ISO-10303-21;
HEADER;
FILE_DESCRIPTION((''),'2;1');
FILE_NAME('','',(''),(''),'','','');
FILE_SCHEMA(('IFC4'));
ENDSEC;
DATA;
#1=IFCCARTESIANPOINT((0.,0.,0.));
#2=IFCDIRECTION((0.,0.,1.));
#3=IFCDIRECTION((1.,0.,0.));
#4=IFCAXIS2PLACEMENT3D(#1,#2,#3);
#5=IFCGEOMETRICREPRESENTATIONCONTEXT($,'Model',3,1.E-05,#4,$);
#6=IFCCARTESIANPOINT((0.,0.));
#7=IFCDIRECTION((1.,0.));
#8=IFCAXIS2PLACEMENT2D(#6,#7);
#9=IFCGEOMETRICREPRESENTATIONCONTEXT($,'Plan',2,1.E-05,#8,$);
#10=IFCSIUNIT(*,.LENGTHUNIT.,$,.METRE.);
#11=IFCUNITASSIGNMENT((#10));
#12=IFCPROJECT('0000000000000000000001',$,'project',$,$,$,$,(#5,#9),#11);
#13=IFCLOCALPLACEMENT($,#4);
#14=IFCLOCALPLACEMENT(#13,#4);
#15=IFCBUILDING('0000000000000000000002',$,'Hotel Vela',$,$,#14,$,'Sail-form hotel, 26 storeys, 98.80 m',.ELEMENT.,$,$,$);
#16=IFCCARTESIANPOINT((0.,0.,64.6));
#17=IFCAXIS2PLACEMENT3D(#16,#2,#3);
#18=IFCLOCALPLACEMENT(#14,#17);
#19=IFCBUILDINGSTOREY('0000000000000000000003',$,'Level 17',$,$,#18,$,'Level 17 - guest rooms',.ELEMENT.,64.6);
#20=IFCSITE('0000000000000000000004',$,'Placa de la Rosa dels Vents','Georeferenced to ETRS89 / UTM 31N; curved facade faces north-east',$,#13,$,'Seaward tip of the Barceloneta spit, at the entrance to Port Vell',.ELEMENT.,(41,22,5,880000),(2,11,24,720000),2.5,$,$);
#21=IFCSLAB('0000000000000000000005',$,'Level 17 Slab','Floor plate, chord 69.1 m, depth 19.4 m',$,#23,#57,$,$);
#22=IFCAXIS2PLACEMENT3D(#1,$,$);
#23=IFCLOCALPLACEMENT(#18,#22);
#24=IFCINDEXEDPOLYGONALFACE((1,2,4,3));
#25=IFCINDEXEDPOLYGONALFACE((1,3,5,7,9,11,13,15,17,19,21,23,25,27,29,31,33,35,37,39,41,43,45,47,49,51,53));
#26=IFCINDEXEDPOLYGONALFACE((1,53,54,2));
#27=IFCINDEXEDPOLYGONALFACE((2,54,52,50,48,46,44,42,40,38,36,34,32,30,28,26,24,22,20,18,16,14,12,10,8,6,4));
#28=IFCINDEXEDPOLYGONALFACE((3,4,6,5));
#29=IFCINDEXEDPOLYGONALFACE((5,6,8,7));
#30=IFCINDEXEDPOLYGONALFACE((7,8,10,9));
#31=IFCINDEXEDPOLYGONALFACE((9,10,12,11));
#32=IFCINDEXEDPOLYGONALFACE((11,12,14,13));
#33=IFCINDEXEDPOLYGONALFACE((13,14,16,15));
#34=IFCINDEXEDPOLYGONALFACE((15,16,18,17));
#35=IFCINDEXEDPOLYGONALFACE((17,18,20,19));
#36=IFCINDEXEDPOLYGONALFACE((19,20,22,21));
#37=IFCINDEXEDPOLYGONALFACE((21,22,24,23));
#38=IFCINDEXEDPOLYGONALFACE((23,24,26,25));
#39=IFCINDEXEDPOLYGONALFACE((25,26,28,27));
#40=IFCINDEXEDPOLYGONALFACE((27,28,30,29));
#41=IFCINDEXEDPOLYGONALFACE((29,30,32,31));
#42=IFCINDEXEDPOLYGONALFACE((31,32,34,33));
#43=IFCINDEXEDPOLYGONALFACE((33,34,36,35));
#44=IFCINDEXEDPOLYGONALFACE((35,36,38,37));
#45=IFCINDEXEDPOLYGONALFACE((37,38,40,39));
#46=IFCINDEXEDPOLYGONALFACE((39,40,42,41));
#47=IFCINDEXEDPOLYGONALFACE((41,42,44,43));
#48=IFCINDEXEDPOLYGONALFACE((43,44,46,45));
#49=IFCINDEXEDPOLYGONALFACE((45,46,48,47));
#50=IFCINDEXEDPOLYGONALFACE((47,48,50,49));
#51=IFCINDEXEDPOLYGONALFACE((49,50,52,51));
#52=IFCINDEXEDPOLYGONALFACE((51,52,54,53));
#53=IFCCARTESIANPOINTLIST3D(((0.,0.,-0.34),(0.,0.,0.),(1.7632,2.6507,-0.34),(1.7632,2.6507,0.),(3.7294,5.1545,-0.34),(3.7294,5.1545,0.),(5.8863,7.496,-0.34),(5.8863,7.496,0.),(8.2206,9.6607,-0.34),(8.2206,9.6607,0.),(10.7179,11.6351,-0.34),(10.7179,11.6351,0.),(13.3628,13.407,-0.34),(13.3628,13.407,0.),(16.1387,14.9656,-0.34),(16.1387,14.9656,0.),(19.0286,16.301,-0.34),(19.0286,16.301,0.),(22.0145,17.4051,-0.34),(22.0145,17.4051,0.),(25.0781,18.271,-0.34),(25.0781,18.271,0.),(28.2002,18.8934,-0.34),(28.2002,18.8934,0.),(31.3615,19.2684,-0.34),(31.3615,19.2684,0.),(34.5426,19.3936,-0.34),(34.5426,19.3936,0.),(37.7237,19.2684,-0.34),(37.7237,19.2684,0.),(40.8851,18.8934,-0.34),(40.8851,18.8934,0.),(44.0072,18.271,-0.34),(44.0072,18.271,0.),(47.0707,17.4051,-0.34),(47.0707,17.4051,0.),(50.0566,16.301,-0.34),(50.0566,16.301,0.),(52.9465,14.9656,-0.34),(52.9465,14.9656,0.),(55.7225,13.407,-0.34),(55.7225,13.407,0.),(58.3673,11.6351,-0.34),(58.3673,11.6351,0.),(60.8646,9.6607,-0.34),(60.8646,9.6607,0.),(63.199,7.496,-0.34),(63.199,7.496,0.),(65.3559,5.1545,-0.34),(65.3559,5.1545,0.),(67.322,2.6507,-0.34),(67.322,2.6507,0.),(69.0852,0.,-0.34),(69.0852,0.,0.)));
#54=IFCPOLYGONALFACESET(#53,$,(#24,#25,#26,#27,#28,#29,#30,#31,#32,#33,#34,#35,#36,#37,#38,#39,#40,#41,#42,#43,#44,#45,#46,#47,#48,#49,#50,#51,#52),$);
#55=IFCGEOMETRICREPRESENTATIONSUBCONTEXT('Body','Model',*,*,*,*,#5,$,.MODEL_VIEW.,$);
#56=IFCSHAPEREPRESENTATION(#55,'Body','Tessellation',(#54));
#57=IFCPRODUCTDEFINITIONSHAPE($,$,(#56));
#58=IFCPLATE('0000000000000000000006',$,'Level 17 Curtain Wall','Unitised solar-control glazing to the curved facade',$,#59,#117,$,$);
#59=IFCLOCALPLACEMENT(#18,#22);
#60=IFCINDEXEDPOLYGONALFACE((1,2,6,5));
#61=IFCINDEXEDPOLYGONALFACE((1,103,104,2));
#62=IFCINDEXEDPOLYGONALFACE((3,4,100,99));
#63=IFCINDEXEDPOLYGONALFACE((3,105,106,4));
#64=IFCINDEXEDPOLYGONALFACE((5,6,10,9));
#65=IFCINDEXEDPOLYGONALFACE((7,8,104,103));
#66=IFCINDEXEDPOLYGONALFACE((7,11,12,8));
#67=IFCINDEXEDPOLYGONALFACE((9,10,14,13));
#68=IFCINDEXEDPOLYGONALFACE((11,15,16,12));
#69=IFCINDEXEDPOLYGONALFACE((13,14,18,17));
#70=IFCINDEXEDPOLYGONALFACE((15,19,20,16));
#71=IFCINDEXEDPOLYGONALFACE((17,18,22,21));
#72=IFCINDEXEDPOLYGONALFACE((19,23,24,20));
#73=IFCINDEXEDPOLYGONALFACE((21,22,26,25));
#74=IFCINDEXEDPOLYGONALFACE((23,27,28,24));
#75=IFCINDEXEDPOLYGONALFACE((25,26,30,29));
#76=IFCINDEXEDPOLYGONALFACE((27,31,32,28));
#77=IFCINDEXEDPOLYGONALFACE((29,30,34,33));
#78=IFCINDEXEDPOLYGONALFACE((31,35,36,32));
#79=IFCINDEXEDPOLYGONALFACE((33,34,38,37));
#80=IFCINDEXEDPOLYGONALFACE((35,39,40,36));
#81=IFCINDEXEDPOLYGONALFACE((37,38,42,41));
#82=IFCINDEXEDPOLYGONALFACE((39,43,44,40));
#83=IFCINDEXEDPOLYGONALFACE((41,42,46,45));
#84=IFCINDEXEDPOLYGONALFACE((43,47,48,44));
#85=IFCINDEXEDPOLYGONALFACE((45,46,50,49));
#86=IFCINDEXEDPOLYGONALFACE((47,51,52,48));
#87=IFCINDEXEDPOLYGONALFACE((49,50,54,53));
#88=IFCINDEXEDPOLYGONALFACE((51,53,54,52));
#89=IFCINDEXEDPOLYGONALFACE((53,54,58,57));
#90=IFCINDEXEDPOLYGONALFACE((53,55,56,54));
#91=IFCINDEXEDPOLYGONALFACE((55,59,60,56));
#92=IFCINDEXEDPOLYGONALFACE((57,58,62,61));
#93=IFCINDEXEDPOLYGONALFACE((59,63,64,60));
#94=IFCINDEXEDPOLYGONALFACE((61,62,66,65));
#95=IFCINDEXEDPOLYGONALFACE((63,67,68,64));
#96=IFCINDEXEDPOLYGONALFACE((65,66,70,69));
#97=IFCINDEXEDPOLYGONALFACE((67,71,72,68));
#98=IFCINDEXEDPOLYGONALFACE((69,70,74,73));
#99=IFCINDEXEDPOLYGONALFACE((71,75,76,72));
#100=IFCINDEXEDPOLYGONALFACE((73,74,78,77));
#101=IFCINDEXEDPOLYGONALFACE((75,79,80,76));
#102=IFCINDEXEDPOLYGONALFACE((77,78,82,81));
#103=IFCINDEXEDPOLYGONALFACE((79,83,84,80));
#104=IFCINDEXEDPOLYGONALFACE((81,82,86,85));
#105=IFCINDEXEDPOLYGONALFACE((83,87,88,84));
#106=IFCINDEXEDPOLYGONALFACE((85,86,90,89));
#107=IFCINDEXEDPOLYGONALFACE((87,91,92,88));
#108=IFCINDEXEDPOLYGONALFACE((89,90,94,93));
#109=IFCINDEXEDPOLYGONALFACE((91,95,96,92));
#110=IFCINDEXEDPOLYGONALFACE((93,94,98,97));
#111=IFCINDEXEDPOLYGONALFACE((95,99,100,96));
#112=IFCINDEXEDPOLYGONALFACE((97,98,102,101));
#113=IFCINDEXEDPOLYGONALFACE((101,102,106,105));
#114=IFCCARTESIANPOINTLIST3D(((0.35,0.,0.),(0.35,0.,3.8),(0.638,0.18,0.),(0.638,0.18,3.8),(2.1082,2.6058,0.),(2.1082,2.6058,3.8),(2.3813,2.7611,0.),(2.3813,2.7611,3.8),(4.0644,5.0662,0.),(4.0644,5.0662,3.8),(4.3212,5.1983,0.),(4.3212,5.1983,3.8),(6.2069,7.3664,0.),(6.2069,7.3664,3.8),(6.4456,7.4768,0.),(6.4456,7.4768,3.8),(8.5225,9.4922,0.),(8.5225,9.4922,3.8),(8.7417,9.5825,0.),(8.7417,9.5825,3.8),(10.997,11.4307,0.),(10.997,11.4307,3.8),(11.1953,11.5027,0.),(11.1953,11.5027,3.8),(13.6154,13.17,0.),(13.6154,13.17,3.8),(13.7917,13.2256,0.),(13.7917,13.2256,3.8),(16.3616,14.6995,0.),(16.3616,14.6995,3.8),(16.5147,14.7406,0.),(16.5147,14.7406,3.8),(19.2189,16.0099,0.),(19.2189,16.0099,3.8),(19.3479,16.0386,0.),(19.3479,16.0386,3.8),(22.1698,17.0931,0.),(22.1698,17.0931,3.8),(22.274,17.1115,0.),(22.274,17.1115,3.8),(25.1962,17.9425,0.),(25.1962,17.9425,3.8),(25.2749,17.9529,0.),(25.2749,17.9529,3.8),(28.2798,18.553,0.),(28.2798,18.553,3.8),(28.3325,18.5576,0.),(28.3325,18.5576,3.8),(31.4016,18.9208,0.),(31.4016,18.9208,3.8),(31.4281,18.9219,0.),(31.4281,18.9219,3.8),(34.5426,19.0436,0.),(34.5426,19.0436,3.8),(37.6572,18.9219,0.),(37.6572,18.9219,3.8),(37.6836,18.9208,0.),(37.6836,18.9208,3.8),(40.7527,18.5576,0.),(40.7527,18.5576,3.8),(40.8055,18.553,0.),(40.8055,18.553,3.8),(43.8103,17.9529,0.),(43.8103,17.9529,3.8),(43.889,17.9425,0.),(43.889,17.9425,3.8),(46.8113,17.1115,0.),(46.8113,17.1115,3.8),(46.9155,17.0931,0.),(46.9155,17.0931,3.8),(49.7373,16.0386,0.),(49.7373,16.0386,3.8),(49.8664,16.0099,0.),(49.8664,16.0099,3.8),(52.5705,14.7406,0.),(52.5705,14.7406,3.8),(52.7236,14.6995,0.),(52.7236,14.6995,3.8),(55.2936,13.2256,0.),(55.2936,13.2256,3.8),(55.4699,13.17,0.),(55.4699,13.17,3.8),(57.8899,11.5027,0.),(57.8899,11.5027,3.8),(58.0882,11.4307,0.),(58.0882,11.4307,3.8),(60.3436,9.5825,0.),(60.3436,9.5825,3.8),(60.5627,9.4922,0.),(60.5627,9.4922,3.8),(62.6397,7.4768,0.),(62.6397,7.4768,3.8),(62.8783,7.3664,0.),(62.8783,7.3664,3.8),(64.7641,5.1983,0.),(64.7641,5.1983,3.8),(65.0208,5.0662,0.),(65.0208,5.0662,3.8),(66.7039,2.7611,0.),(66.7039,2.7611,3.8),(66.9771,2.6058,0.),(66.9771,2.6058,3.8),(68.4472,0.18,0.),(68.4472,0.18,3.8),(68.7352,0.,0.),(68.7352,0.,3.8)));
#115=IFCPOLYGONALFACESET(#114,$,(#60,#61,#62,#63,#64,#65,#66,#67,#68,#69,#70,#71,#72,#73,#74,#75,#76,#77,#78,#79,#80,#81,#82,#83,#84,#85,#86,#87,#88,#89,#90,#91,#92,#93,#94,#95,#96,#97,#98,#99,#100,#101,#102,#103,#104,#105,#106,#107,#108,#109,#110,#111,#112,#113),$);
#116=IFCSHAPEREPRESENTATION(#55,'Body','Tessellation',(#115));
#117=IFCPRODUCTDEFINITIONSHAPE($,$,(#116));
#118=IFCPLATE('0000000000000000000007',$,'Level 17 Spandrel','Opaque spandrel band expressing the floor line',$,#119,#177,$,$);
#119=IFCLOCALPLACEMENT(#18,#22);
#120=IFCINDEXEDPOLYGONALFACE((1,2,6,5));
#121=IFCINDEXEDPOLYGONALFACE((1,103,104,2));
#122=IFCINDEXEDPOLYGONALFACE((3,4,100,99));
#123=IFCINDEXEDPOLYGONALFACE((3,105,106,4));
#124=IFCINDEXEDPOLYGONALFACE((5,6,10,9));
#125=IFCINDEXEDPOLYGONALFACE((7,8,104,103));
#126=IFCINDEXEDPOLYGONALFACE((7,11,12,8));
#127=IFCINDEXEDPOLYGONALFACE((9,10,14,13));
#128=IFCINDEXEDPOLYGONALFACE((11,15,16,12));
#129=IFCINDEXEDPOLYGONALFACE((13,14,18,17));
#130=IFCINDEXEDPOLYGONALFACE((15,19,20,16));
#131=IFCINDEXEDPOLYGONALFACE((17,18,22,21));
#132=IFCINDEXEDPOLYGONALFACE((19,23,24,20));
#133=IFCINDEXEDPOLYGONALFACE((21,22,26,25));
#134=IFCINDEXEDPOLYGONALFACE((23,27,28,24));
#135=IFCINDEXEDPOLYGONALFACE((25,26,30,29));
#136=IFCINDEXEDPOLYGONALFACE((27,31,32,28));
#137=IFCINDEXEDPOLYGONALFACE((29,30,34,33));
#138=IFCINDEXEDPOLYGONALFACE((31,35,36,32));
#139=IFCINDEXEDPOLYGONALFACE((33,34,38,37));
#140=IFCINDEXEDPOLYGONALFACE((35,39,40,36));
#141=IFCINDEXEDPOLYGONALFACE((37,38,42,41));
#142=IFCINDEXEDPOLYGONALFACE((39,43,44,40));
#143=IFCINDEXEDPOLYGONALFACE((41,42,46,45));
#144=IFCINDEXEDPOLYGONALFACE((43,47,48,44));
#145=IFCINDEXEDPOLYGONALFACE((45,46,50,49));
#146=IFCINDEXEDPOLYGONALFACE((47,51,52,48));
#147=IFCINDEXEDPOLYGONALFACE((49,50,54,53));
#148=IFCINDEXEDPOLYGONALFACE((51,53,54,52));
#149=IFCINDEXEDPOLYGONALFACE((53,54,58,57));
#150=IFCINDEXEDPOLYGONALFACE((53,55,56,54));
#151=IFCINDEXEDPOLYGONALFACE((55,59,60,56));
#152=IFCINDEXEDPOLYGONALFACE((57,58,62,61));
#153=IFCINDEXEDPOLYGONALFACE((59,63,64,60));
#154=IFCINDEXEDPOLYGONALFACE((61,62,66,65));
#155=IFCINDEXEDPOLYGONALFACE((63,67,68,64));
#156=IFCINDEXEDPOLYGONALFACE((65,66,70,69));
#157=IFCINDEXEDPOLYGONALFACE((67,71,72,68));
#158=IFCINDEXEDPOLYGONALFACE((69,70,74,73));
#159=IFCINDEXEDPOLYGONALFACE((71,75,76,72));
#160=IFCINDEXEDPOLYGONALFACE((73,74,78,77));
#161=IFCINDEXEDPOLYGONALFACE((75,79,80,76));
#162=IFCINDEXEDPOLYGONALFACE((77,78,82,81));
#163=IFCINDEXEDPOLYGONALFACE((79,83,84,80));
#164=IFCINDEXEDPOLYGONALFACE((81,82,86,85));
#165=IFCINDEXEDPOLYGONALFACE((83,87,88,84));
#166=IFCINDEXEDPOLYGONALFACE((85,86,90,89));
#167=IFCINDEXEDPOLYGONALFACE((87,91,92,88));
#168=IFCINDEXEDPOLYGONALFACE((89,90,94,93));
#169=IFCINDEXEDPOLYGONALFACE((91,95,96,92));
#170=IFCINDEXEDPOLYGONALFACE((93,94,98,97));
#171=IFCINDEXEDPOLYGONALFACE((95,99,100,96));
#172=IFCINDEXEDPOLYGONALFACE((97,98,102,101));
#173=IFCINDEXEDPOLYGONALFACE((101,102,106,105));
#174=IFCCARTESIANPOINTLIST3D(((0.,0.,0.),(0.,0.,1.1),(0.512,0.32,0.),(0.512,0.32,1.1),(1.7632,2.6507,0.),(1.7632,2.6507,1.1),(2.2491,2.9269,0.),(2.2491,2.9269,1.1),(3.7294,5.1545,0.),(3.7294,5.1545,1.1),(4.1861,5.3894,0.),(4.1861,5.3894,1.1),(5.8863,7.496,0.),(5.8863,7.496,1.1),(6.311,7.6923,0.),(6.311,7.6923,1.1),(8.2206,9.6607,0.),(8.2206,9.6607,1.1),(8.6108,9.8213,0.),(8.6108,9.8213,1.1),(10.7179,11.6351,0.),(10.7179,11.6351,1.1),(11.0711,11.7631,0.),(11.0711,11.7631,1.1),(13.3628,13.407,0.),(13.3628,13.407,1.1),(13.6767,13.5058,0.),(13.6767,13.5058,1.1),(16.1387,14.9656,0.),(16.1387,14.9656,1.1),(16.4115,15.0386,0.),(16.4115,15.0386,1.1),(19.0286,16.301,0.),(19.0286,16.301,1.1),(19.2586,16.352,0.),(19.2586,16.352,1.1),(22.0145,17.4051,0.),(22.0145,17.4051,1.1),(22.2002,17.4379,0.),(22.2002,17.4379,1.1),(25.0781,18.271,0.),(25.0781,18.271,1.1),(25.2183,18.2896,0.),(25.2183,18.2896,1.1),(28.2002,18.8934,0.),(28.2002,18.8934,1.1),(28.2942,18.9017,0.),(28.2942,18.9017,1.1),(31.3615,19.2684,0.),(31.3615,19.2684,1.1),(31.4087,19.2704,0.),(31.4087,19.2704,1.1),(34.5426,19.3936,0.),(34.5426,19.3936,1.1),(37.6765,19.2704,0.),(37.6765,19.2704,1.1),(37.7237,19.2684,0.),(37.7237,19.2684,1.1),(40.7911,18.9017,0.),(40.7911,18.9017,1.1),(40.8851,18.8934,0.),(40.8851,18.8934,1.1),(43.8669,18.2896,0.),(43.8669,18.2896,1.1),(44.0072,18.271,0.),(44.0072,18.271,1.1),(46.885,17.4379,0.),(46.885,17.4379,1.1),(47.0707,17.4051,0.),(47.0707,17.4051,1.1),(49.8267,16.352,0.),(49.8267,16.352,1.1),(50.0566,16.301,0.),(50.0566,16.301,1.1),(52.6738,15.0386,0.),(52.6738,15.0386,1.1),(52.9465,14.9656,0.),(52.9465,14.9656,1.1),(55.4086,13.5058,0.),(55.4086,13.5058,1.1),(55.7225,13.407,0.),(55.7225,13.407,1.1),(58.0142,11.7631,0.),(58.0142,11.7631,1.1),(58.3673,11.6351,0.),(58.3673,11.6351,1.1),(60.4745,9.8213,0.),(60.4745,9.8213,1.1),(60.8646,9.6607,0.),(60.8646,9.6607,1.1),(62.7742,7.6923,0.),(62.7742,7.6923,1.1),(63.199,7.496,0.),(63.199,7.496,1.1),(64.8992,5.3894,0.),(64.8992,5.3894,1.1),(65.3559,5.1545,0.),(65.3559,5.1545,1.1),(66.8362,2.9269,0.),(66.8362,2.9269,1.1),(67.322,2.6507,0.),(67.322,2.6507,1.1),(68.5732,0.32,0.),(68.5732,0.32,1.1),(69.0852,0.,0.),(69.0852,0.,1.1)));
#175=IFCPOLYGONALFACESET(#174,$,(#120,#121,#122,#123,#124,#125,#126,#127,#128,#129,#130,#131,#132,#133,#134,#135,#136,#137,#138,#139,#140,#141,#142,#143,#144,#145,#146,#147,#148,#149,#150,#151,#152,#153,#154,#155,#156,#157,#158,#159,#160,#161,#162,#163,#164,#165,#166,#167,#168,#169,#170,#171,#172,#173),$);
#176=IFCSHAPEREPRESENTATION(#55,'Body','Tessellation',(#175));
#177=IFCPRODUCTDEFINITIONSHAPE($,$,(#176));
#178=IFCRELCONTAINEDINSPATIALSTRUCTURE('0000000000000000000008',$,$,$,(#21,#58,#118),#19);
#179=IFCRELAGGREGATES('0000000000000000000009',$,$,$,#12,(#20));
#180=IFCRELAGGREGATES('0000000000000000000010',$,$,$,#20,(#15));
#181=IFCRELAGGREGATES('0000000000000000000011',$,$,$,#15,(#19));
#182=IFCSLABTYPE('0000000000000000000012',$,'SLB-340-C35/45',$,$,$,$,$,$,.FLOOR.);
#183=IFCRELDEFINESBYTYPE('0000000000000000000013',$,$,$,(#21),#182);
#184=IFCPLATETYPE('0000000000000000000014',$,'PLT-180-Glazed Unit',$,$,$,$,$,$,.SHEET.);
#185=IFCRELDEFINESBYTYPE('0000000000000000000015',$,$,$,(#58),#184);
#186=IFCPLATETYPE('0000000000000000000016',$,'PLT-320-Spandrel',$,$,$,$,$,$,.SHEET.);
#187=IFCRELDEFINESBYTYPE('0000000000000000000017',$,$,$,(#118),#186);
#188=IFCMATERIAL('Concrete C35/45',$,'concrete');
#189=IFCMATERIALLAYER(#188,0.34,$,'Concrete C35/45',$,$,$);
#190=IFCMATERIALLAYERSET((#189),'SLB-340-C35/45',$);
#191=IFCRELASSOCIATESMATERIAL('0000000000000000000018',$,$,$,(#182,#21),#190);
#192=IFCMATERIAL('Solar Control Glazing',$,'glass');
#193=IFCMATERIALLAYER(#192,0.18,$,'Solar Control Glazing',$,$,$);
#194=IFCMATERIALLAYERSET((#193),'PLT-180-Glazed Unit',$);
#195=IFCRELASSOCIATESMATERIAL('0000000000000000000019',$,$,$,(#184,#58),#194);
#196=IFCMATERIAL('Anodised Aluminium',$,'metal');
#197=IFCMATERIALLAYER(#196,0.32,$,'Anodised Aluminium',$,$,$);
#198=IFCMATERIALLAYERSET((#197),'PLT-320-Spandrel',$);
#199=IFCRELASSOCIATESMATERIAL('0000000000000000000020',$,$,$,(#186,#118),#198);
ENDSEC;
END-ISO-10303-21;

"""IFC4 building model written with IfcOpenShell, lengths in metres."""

from ifc_helpers import new_model, si_unit, frame, origin_with_axes, origin_2d_with_axis, place, context, subcontext, project, spatial, line, indexed_curve, outline, extrude, material, layer, layer_set, layer_usage, type_object, element, save


model = new_model("IFC4")

# Units and contexts
model_context = context("Model", 3, precision=1e-05, world=origin_with_axes())
plan_context = context("Plan", 2, precision=1e-05, world=origin_2d_with_axis())
body_context = subcontext(model_context, "Body", "Model", "MODEL_VIEW")
ifc_project = project(units=[si_unit("LENGTHUNIT", "METRE")], contexts=[model_context, plan_context])

# Site, building, storey
site_placement = place(None, origin_with_axes())
site = spatial("IfcSite", under=ifc_project, at=site_placement, Name="Placa de la Rosa dels Vents", Description="Georeferenced to ETRS89 / UTM 31N; curved facade faces north-east", LongName="Seaward tip of the Barceloneta spit, at the entrance to Port Vell", CompositionType="ELEMENT", RefLatitude=(41, 22, 5, 880000), RefLongitude=(2, 11, 24, 720000), RefElevation=2.5)
building_placement = place(site_placement, origin_with_axes())
building = spatial("IfcBuilding", under=site, at=building_placement, Name="Hotel Vela", LongName="Sail-form hotel, 26 storeys, 98.80 m", CompositionType="ELEMENT")
storey_placement = place(building_placement, frame((0.0, 0.0, 64.6), z_axis=(0.0, 0.0, 1.0), x_axis=(1.0, 0.0, 0.0)))
storey = spatial("IfcBuildingStorey", under=building, at=storey_placement, Name="Level 17", LongName="Level 17 - guest rooms", CompositionType="ELEMENT", Elevation=64.6)

# Slab
ifc_material_1 = material(Name="Concrete C35/45", Category="concrete")
ifc_layer_1 = layer(ifc_material_1, 0.34, Name="Concrete C35/45")
ifc_layer_set_1 = layer_set([ifc_layer_1], Name="SLB-340-C35/45")
ifc_layer_usage_1 = layer_usage(ifc_layer_set_1, "AXIS3", "POSITIVE", 0.0)
slab_type = type_object("IfcSlabType", Name="SLB-340-C35/45", PredefinedType="FLOOR", material=ifc_layer_set_1)
slab_placement = place(storey_placement, frame((0.0, 0.0, -0.34), z_axis=(0.0, 0.0, 1.0), x_axis=(1.0, 0.0, 0.0)))
element("IfcSlab", 1, at=slab_placement, inside=storey, type_object=slab_type, material=ifc_layer_usage_1, Name="Level 17 Slab", Description="Floor plate, chord 69.1 m, depth 19.4 m", context=body_context, shape_type="SweptSolid", body=[
    extrude(outline(indexed_curve([(0.0, 0.0), (69.0852, 0.0), (67.322, 2.6507), (65.3559, 5.1545), (63.199, 7.496), (60.8646, 9.6607), (58.3673, 11.6351), (55.7225, 13.407), (52.9465, 14.9656), (50.0566, 16.301), (47.0707, 17.4051), (44.0072, 18.271), (40.8851, 18.8934), (37.7237, 19.2684), (34.5426, 19.3936), (31.3615, 19.2684), (28.2002, 18.8934), (25.0781, 18.271), (22.0145, 17.4051), (19.0286, 16.301), (16.1387, 14.9656), (13.3628, 13.407), (10.7179, 11.6351), (8.2206, 9.6607), (5.8863, 7.496), (3.7294, 5.1545), (1.7632, 2.6507)], segments=[line(1, 2, 3, 4, 5, 6, 7, 8, 9, 10, 11, 12, 13, 14, 15, 16, 17, 18, 19, 20, 21, 22, 23, 24, 25, 26, 27, 1)])), origin_with_axes(), (0.0, 0.0, 1.0), 0.34),
])

# Plates
ifc_material_2 = material(Name="Solar Control Glazing", Category="glass")
ifc_layer_2 = layer(ifc_material_2, 0.18, Name="Solar Control Glazing")
ifc_layer_set_2 = layer_set([ifc_layer_2], Name="PLT-180-Glazed Unit")
ifc_layer_usage_2 = layer_usage(ifc_layer_set_2, "AXIS2", "POSITIVE", 0.0)
plate_type_1 = type_object("IfcPlateType", Name="PLT-180-Glazed Unit", PredefinedType="SHEET", material=ifc_layer_set_2)
plate_1_placement = place(storey_placement, frame((0.35, 0.0, 0.0), z_axis=(0.0, 0.0, 1.0), x_axis=(1.0, 0.0, 0.0)))
element("IfcPlate", 2, at=plate_1_placement, inside=storey, type_object=plate_type_1, material=ifc_layer_usage_2, Name="Level 17 Curtain Wall", Description="Unitised solar-control glazing to the curved facade", context=body_context, shape_type="SweptSolid", body=[
    extrude(outline(indexed_curve([(68.3852, 0.0), (66.6271, 2.6058), (64.6708, 5.0662), (62.5283, 7.3664), (60.2127, 9.4922), (57.7382, 11.4307), (55.1199, 13.17), (52.3736, 14.6995), (49.5164, 16.0099), (46.5655, 17.0931), (43.539, 17.9425), (40.4555, 18.553), (37.3336, 18.9208), (34.1926, 19.0436), (31.0516, 18.9208), (27.9298, 18.553), (24.8462, 17.9425), (21.8198, 17.0931), (18.8689, 16.0099), (16.0116, 14.6995), (13.2654, 13.17), (10.647, 11.4307), (8.1725, 9.4922), (5.8569, 7.3664), (3.7144, 5.0662), (1.7582, 2.6058), (0.0, 0.0), (68.0972, 0.18), (2.0313, 2.7611), (3.9712, 5.1983), (6.0956, 7.4768), (8.3917, 9.5825), (10.8453, 11.5027), (13.4417, 13.2256), (16.1647, 14.7406), (18.9979, 16.0386), (21.924, 17.1115), (24.9249, 17.9529), (27.9825, 18.5576), (31.0781, 18.9219), (34.1926, 19.0436), (37.3072, 18.9219), (40.4027, 18.5576), (43.4603, 17.9529), (46.4613, 17.1115), (49.3873, 16.0386), (52.2205, 14.7406), (54.9436, 13.2256), (57.5399, 11.5027), (59.9936, 9.5825), (62.2897, 7.4768), (64.4141, 5.1983), (66.3539, 2.7611), (0.288, 0.18)], segments=[line(1, 2, 3, 4, 5, 6, 7, 8, 9, 10, 11, 12, 13, 14, 15, 16, 17, 18, 19, 20, 21, 22, 23, 24, 25, 26, 27, 28, 29, 30, 31, 32, 33, 34, 35, 36, 37, 38, 39, 40, 41, 42, 43, 44, 45, 46, 47, 48, 49, 50, 51, 52, 53, 54, 1)])), origin_with_axes(), (0.0, 0.0, 1.0), 3.8),
])
ifc_material_3 = material(Name="Anodised Aluminium", Category="metal")
ifc_layer_3 = layer(ifc_material_3, 0.32, Name="Anodised Aluminium")
ifc_layer_set_3 = layer_set([ifc_layer_3], Name="PLT-320-Spandrel")
ifc_layer_usage_3 = layer_usage(ifc_layer_set_3, "AXIS2", "POSITIVE", 0.0)
plate_type_2 = type_object("IfcPlateType", Name="PLT-320-Spandrel", PredefinedType="SHEET", material=ifc_layer_set_3)
plate_2_placement = place(storey_placement, origin_with_axes())
element("IfcPlate", 3, at=plate_2_placement, inside=storey, type_object=plate_type_2, material=ifc_layer_usage_3, Name="Level 17 Spandrel", Description="Opaque spandrel band expressing the floor line", context=body_context, shape_type="SweptSolid", body=[
    extrude(outline(indexed_curve([(69.0852, 0.0), (67.322, 2.6507), (65.3559, 5.1545), (63.199, 7.496), (60.8646, 9.6607), (58.3673, 11.6351), (55.7225, 13.407), (52.9465, 14.9656), (50.0566, 16.301), (47.0707, 17.4051), (44.0072, 18.271), (40.8851, 18.8934), (37.7237, 19.2684), (34.5426, 19.3936), (31.3615, 19.2684), (28.2002, 18.8934), (25.0781, 18.271), (22.0145, 17.4051), (19.0286, 16.301), (16.1387, 14.9656), (13.3628, 13.407), (10.7179, 11.6351), (8.2206, 9.6607), (5.8863, 7.496), (3.7294, 5.1545), (1.7632, 2.6507), (0.0, 0.0), (68.5732, 0.32), (2.2491, 2.9269), (4.1861, 5.3894), (6.311, 7.6923), (8.6108, 9.8213), (11.0711, 11.7631), (13.6767, 13.5058), (16.4115, 15.0386), (19.2586, 16.352), (22.2002, 17.4379), (25.2183, 18.2896), (28.2942, 18.9017), (31.4087, 19.2704), (34.5426, 19.3936), (37.6765, 19.2704), (40.7911, 18.9017), (43.8669, 18.2896), (46.885, 17.4379), (49.8267, 16.352), (52.6738, 15.0386), (55.4086, 13.5058), (58.0142, 11.7631), (60.4745, 9.8213), (62.7742, 7.6923), (64.8992, 5.3894), (66.8362, 2.9269), (0.512, 0.32)], segments=[line(1, 2, 3, 4, 5, 6, 7, 8, 9, 10, 11, 12, 13, 14, 15, 16, 17, 18, 19, 20, 21, 22, 23, 24, 25, 26, 27, 28, 29, 30, 31, 32, 33, 34, 35, 36, 37, 38, 39, 40, 41, 42, 43, 44, 45, 46, 47, 48, 49, 50, 51, 52, 53, 54, 1)])), origin_with_axes(), (0.0, 0.0, 1.0), 1.1),
])

save(model, "model.ifc")
